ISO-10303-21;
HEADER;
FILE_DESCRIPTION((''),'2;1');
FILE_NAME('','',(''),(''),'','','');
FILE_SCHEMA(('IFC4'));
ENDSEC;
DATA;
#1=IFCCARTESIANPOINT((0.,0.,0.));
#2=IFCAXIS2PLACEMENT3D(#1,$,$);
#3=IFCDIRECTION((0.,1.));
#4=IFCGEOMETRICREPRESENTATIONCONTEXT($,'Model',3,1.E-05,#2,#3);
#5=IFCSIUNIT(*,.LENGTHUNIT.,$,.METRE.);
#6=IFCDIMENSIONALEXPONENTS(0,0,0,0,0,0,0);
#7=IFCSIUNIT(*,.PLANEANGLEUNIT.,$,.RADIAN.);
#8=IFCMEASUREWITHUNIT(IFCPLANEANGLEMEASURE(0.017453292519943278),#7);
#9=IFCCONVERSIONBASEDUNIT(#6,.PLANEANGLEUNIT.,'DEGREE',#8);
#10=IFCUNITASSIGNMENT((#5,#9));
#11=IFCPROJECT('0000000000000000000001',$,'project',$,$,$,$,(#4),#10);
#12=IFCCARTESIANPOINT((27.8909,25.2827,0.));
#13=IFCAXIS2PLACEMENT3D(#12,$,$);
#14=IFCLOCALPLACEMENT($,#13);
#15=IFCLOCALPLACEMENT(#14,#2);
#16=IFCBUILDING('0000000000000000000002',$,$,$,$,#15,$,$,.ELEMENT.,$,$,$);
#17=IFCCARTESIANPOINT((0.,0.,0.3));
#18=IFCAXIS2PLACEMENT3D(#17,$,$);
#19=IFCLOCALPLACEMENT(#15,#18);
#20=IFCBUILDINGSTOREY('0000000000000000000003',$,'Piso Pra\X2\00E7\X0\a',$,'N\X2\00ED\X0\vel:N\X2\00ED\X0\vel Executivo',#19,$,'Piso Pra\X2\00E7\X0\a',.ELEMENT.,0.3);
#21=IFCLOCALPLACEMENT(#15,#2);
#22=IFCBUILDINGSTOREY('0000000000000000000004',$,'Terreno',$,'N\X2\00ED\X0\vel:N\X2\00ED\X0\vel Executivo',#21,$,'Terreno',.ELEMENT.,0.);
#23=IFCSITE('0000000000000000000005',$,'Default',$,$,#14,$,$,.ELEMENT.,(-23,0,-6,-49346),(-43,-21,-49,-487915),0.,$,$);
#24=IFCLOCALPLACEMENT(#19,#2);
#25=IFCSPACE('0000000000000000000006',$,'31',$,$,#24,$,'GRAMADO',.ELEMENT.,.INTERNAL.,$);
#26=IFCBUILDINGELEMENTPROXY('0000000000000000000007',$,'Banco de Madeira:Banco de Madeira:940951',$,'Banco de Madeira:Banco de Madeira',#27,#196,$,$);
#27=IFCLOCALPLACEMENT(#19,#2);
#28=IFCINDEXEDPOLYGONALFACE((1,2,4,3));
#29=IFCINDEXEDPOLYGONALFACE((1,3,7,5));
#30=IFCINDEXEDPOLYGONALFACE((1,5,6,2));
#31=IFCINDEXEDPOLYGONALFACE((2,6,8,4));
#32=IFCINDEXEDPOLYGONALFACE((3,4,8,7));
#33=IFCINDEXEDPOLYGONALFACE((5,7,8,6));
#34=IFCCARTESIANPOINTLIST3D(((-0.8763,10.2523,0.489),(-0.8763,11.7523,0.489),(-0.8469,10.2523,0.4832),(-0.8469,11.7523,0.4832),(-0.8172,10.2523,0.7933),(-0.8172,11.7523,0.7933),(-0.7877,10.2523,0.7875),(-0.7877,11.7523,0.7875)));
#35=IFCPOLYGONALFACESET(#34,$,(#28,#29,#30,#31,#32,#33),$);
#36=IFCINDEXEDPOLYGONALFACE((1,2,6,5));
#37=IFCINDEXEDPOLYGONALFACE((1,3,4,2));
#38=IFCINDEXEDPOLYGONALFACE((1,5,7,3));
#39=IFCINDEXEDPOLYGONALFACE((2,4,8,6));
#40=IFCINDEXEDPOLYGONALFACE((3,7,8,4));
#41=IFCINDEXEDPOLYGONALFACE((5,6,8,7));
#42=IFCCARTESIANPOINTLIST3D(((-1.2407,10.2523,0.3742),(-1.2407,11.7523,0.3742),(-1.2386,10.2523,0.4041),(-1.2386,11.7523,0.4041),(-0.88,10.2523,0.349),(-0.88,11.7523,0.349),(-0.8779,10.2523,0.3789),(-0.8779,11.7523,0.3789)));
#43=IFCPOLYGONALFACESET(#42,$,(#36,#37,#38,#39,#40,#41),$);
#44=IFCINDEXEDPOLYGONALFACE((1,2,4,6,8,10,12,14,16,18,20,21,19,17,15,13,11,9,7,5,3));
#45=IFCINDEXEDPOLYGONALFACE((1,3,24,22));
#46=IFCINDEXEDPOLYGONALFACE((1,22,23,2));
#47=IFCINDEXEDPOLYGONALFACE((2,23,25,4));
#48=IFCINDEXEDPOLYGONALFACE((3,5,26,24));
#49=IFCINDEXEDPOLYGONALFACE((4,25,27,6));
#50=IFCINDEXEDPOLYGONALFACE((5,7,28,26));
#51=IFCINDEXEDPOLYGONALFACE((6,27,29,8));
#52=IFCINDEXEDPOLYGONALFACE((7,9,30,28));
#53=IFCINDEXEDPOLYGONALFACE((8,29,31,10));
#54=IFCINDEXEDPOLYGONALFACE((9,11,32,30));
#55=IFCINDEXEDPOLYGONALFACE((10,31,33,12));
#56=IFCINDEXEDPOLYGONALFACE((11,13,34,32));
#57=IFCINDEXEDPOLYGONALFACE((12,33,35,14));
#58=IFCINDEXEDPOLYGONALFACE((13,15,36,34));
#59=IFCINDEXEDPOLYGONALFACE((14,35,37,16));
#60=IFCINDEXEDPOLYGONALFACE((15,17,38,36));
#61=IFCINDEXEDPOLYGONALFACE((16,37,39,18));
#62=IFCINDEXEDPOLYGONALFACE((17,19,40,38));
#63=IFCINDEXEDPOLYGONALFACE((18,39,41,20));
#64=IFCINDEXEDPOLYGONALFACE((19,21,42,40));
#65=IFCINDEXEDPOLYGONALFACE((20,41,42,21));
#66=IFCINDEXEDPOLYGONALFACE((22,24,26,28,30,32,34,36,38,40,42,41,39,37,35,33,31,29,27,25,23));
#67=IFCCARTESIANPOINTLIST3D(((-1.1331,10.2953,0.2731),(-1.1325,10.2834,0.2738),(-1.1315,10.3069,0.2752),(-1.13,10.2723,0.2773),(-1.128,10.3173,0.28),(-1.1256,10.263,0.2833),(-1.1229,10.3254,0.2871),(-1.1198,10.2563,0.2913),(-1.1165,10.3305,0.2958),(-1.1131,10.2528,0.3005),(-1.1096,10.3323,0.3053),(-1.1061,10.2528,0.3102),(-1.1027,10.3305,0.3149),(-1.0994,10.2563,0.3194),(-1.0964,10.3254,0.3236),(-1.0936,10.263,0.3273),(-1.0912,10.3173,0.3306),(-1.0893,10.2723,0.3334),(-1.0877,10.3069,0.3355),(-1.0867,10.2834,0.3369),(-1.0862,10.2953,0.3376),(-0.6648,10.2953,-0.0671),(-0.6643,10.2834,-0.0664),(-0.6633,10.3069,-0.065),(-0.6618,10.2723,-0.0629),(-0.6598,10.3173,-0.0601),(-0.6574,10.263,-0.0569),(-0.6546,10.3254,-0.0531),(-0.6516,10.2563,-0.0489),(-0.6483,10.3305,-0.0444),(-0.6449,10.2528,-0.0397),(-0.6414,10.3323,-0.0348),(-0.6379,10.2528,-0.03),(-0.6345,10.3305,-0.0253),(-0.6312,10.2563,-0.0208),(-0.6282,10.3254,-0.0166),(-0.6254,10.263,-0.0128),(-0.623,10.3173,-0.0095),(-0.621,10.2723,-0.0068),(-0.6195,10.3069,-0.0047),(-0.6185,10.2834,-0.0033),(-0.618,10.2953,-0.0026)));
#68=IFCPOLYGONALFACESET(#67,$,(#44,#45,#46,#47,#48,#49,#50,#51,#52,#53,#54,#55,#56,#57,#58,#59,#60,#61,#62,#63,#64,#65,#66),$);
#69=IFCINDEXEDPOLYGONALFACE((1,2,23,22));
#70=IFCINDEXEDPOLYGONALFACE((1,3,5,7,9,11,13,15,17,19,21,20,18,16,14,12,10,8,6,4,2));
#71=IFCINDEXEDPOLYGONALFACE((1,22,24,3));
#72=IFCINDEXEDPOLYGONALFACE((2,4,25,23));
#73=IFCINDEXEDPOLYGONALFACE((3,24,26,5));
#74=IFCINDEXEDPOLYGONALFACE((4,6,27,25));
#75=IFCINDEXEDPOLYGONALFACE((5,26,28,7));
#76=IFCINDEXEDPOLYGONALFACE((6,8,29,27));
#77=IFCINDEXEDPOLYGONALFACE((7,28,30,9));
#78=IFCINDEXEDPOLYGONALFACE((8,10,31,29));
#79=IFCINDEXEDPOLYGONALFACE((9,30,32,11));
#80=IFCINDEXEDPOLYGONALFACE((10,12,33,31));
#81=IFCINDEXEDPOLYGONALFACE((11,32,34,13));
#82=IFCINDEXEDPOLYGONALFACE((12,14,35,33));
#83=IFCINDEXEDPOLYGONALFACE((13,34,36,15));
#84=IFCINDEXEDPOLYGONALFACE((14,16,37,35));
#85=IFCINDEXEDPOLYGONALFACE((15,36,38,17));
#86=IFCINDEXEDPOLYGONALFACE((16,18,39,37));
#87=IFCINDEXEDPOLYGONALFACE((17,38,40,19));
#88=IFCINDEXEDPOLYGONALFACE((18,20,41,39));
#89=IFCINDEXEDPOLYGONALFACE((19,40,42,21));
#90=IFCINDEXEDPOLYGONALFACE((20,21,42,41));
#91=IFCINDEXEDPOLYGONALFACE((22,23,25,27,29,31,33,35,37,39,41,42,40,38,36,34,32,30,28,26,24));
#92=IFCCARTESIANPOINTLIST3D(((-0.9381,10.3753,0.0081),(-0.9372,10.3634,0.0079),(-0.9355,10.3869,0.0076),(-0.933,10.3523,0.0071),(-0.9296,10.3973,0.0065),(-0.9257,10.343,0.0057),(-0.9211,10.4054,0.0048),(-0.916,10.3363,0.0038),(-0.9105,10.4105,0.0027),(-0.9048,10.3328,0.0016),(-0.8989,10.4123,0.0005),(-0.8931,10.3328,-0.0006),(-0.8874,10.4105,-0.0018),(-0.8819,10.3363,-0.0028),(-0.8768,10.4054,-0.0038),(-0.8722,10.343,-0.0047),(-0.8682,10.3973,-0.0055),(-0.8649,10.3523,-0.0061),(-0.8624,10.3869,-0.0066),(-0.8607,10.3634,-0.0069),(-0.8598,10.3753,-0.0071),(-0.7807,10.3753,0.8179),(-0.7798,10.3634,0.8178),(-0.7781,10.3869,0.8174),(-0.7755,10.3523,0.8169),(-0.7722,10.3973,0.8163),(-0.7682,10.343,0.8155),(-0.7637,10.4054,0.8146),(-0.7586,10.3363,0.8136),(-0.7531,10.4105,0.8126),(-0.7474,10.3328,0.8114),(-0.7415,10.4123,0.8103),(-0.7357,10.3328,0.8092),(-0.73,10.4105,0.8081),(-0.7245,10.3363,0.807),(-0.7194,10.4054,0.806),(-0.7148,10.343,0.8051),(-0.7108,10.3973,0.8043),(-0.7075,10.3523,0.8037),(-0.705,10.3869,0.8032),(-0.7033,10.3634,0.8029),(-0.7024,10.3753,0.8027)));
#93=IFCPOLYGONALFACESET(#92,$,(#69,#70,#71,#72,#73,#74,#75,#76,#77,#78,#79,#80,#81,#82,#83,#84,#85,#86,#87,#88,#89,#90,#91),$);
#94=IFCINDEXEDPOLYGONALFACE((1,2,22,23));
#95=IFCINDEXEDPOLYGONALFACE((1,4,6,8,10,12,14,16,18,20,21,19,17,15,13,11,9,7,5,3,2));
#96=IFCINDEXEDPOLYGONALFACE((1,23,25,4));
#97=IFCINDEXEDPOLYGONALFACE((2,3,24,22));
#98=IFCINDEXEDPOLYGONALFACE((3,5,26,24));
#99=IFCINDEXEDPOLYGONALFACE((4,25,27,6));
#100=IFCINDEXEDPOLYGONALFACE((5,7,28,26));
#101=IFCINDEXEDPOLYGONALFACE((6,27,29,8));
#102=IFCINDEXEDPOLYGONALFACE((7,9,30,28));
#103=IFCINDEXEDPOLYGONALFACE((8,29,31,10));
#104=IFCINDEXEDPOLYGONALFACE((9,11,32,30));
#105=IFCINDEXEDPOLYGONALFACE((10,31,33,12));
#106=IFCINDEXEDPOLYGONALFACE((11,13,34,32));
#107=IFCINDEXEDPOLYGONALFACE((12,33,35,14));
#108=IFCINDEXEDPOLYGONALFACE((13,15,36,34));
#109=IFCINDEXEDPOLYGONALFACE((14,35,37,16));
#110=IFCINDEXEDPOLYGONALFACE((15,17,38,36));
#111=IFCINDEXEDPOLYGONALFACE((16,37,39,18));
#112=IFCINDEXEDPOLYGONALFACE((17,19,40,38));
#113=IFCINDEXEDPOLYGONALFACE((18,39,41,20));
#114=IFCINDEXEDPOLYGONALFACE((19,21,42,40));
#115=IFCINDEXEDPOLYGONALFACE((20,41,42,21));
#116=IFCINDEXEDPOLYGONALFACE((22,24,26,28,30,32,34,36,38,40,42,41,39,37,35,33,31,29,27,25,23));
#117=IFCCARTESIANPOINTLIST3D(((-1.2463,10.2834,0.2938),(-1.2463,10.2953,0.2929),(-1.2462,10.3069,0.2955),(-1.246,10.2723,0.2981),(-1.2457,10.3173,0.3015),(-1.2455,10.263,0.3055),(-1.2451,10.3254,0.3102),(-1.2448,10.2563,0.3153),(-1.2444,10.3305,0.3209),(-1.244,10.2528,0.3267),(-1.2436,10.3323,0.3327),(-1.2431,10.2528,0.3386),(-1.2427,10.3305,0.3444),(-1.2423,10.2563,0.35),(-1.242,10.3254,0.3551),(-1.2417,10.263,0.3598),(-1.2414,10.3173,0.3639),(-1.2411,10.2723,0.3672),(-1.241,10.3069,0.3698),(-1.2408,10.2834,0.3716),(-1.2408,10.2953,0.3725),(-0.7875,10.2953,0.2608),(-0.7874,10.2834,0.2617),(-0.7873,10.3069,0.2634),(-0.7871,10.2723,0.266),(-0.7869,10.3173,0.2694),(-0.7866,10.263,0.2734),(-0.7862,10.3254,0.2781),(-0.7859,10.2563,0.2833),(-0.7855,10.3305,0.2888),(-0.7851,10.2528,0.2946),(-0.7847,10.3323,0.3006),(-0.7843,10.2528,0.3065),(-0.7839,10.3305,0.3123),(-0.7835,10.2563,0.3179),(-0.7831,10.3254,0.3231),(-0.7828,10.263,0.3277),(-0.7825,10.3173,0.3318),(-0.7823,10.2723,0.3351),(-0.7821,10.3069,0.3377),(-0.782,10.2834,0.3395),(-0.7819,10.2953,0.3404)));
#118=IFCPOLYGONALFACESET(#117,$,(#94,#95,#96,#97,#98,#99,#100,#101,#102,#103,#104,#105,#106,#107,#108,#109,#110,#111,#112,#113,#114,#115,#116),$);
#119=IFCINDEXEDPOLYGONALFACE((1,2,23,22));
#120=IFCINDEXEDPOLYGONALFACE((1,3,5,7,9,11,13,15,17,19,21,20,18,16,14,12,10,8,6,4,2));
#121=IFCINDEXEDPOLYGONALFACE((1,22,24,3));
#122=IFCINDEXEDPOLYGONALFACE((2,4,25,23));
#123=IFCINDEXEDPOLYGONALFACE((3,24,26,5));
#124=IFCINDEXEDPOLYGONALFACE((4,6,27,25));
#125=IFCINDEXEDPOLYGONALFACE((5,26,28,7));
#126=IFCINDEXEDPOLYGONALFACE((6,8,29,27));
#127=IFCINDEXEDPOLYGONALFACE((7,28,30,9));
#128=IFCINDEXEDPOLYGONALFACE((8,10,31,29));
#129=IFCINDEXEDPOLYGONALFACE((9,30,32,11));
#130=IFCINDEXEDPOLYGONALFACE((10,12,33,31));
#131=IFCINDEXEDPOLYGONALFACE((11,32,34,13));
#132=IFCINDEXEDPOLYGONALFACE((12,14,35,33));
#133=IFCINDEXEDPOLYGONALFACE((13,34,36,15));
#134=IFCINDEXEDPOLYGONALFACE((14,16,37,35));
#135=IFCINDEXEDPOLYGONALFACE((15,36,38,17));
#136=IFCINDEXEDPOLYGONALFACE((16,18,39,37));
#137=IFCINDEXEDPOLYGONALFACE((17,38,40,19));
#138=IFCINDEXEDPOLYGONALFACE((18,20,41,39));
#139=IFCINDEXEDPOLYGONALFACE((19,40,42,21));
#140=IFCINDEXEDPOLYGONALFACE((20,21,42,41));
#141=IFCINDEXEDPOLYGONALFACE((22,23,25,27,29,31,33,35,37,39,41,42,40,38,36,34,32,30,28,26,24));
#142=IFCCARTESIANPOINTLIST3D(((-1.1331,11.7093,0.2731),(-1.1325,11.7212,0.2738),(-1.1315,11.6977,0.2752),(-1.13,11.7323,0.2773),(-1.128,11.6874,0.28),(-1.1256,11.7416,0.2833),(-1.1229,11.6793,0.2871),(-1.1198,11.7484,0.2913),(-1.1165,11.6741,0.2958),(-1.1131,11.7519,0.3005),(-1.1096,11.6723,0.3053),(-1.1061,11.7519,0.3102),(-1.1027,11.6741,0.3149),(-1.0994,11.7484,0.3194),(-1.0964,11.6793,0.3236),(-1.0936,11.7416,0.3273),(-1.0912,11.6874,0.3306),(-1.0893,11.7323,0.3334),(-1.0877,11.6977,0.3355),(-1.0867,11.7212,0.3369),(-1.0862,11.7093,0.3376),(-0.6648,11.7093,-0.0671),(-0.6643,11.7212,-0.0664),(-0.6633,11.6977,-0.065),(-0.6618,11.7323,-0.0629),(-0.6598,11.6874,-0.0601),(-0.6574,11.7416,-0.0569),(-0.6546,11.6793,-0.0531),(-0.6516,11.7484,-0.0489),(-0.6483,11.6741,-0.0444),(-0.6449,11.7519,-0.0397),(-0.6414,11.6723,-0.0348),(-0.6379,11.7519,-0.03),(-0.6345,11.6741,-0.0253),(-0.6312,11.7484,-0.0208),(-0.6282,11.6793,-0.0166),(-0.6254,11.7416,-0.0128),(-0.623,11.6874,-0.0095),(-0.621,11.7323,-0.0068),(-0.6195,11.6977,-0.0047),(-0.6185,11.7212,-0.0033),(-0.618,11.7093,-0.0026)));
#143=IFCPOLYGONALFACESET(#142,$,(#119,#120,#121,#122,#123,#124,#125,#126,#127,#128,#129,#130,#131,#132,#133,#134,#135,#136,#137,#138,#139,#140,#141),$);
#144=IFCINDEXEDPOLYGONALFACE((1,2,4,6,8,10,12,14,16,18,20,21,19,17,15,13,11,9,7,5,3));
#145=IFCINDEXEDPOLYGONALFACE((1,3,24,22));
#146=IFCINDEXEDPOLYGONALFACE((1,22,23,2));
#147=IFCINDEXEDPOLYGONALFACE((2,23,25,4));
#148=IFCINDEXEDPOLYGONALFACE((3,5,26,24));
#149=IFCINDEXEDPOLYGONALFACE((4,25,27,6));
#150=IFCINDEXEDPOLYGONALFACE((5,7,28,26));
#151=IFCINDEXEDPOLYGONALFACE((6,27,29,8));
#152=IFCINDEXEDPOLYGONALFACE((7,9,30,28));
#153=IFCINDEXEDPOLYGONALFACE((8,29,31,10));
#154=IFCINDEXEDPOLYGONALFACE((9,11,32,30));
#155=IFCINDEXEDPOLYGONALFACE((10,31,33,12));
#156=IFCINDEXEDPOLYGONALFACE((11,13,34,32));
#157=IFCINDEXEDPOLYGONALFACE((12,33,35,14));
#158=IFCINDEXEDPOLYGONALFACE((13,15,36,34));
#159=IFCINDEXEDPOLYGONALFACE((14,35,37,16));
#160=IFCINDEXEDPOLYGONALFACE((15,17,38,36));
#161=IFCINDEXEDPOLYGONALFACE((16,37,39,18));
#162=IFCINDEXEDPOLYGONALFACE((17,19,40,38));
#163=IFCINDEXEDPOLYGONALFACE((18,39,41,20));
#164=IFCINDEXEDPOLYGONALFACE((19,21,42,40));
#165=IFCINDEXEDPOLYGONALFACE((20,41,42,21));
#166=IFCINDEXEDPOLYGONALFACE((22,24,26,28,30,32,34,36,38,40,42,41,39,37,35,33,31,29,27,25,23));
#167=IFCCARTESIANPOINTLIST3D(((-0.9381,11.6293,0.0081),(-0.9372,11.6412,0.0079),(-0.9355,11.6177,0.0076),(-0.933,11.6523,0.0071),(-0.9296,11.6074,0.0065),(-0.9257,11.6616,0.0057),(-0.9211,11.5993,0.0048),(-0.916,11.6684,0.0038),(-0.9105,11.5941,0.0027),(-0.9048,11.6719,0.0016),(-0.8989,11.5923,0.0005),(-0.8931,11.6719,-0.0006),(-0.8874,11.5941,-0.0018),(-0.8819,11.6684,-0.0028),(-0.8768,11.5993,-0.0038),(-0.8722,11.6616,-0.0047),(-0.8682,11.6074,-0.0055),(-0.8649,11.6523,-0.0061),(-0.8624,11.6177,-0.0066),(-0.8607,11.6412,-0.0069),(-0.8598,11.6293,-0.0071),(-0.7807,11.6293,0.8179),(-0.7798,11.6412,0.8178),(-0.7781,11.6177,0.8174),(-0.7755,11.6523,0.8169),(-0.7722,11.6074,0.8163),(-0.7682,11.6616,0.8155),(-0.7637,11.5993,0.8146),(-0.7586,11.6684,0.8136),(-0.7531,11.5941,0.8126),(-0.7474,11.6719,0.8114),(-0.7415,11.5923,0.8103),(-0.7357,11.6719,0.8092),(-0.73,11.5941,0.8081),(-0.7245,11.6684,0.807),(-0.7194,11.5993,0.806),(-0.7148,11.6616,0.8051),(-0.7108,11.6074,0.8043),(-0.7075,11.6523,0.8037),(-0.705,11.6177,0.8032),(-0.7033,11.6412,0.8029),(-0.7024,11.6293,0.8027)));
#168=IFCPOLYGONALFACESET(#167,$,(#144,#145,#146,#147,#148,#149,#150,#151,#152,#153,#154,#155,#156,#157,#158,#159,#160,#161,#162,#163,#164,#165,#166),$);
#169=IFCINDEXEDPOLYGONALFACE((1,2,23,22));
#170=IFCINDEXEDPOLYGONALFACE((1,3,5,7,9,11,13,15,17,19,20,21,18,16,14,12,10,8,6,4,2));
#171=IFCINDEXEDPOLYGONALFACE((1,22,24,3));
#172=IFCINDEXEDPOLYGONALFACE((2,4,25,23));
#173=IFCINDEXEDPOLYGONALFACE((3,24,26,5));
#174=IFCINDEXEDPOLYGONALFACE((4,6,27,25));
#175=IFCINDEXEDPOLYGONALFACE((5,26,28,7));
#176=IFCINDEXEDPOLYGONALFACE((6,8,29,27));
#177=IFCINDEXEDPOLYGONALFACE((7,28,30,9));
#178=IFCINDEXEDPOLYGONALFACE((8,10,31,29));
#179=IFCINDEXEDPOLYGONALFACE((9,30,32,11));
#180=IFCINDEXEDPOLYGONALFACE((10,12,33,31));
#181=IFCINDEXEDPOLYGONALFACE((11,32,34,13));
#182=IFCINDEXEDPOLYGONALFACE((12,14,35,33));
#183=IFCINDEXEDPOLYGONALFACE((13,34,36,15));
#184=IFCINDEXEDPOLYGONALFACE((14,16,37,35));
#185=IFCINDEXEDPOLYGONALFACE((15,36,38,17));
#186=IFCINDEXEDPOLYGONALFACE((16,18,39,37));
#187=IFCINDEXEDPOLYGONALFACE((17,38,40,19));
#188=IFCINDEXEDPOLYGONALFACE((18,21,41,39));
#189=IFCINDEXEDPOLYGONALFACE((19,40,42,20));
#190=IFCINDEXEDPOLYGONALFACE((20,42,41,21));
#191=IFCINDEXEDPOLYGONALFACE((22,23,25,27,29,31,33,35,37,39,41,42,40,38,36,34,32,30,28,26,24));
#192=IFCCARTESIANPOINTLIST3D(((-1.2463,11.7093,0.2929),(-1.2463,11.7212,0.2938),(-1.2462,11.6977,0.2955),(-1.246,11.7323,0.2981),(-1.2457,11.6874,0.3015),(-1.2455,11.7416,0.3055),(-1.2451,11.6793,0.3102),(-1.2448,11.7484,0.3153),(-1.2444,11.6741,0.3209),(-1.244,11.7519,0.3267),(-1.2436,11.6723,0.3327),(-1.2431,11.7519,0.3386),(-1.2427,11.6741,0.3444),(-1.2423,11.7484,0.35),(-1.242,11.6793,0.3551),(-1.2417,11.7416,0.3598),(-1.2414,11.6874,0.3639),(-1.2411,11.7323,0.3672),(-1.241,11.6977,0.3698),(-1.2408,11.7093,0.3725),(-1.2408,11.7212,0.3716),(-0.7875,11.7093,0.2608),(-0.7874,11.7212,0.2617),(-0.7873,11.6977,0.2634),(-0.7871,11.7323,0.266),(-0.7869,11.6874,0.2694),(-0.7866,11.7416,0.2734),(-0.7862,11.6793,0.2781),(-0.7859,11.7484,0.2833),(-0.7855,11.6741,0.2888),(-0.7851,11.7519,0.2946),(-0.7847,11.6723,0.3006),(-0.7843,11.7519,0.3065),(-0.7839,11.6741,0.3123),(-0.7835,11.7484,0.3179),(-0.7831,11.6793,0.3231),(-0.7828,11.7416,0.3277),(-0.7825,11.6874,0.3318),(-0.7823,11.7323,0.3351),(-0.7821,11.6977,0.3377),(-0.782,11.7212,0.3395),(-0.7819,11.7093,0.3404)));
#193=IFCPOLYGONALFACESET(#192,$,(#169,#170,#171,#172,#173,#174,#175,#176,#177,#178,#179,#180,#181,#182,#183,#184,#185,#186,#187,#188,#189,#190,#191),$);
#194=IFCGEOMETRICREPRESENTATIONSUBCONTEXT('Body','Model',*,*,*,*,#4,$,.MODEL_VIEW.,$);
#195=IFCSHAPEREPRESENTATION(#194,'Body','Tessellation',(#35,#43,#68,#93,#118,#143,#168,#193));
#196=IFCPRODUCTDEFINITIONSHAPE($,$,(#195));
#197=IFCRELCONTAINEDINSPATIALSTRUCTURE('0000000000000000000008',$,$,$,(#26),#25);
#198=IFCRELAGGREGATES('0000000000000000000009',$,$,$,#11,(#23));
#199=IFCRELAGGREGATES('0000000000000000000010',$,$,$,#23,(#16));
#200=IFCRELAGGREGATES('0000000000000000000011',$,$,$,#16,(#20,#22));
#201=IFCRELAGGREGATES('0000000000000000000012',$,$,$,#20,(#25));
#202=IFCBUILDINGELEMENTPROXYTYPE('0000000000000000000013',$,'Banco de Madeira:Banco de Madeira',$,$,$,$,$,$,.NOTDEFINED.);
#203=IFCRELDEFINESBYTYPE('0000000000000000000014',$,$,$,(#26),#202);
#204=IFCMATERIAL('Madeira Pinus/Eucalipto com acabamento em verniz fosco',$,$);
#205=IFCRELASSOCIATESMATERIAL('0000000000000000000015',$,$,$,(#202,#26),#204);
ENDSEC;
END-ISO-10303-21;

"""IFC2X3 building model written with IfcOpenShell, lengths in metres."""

from ifc_helpers import new_model, entity, si_unit, converted_unit, direction, frame, frame_2d, origin, place, context, subcontext, project, spatial, rectangle, circle, extrude, source, transform, mapped, material, type_object, type_shapes, element, save


model = new_model("IFC2X3")

# Units and contexts
model_context = context("Model", 3, precision=1e-05, world=origin(), true_north=direction((0.0, 1.0)))
body_context = subcontext(model_context, "Body", "Model", "MODEL_VIEW")
ifc_project = project(units=[si_unit("LENGTHUNIT", "METRE"), converted_unit("PLANEANGLEUNIT", "DEGREE", entity("IfcPlaneAngleMeasure", 0.017453292519943278), si_unit("PLANEANGLEUNIT", "RADIAN"), dimensions=[0, 0, 0, 0, 0, 0, 0])], contexts=[model_context])

# Site, building, storey
site_placement = place(None, frame((27.8909, 25.2827, 0.0)))
site = spatial("IfcSite", under=ifc_project, at=site_placement, Name="Default", CompositionType="ELEMENT", RefLatitude=(-23, 0, -6, -49346), RefLongitude=(-43, -21, -49, -487915), RefElevation=0.0)
building_placement = place(site_placement, origin())
building = spatial("IfcBuilding", under=site, at=building_placement, CompositionType="ELEMENT")
storey_1_placement = place(building_placement, frame((0.0, 0.0, 0.3)))
storey_1 = spatial("IfcBuildingStorey", under=building, at=storey_1_placement, Name="Piso Praça", ObjectType="Nível:Nível Executivo", LongName="Piso Praça", CompositionType="ELEMENT", Elevation=0.3)

# Shared definitions
space_1_placement = place(storey_1_placement, origin())
space_1 = spatial("IfcSpace", under=storey_1, at=space_1_placement, Name="31", LongName="GRAMADO", CompositionType="ELEMENT", InteriorOrExteriorSpace="INTERNAL")

# Building element proxy
ifc_material_1 = material(Name="Madeira Pinus/Eucalipto com acabamento em verniz fosco")
building_element_proxy_type_1 = type_object("IfcBuildingElementProxyType", Name="Banco de Madeira:Banco de Madeira", PredefinedType="NOTDEFINED", material=ifc_material_1)
shared_shape_1 = source(origin(), body_context, "Body", "SweptSolid", [
    extrude(rectangle(XDim=0.31, YDim=0.03, at=frame_2d((0.0, 0.0), x_axis=(1.0, 0.0))), frame((-0.75, 0.1439, 0.6383), z_axis=(1.0, 0.0, 0.0), x_axis=(0.0, 0.190809, 0.981627)), (0.0, 0.0, 1.0), 1.5),
    extrude(rectangle(XDim=0.03, YDim=0.3616, at=frame_2d((0.0, 0.0), x_axis=(0.0, 1.0))), frame((-0.75, -0.0833, 0.3765), z_axis=(1.0, 0.0, 0.0), x_axis=(0.0, 0.997564, -0.069756)), (0.0, 0.0, 1.0), 1.5),
    extrude(circle(Radius=0.04, at=frame_2d((0.0, 0.0), x_axis=(1.0, 0.0))), frame((0.71, 0.3345, -0.0348), z_axis=(0.0, -0.809017, 0.587785), x_axis=(-1.0, 0.0, 0.0)), (0.0, 0.0, 1.0), 0.5788),
    extrude(circle(Radius=0.04, at=frame_2d((0.0, 0.0), x_axis=(1.0, 0.0))), frame((0.63, 0.077, 0.0005), z_axis=(0.0, 0.190809, 0.981627), x_axis=(-1.0, 0.0, 0.0)), (0.0, 0.0, 1.0), 0.825),
    extrude(circle(Radius=0.04, at=frame_2d((0.0, 0.0), x_axis=(1.0, 0.0))), frame((0.71, -0.2676, 0.3327), z_axis=(0.0, 0.997564, -0.069756), x_axis=(-1.0, 0.0, 0.0)), (0.0, 0.0, 1.0), 0.46),
    extrude(circle(Radius=0.04, at=frame_2d((0.0, 0.0), x_axis=(1.0, 0.0))), frame((-0.71, 0.3345, -0.0348), z_axis=(0.0, -0.809017, 0.587785), x_axis=(1.0, 0.0, 0.0)), (0.0, 0.0, 1.0), 0.5788),
    extrude(circle(Radius=0.04, at=frame_2d((0.0, 0.0), x_axis=(1.0, 0.0))), frame((-0.63, 0.077, 0.0005), z_axis=(0.0, 0.190809, 0.981627), x_axis=(1.0, 0.0, 0.0)), (0.0, 0.0, 1.0), 0.825),
    extrude(circle(Radius=0.04, at=frame_2d((0.0, 0.0), x_axis=(1.0, 0.0))), frame((-0.71, -0.2676, 0.3327), z_axis=(0.0, 0.997564, -0.069756), x_axis=(1.0, 0.0, 0.0)), (0.0, 0.0, 1.0), 0.46),
])
type_shapes(building_element_proxy_type_1, [shared_shape_1])
proxy_1_placement = place(space_1_placement, frame((-0.9759, 11.0023, 0.0), z_axis=(0.0, 0.0, 1.0), x_axis=(0.0, -1.0, 0.0)))
element("IfcBuildingElementProxy", 1, at=proxy_1_placement, inside=space_1, type_object=building_element_proxy_type_1, material=ifc_material_1, Name="Banco de Madeira:Banco de Madeira:940951", ObjectType="Banco de Madeira:Banco de Madeira", context=body_context, shape_type="MappedRepresentation", body=[
    mapped(shared_shape_1, transform((0.0, 0.0, 0.0), scale=1.0)),
])

# Shared definitions
storey_2_placement = place(building_placement, origin())
storey_2 = spatial("IfcBuildingStorey", under=building, at=storey_2_placement, Name="Terreno", ObjectType="Nível:Nível Executivo", LongName="Terreno", CompositionType="ELEMENT", Elevation=0.0)

save(model, "model.ifc")
